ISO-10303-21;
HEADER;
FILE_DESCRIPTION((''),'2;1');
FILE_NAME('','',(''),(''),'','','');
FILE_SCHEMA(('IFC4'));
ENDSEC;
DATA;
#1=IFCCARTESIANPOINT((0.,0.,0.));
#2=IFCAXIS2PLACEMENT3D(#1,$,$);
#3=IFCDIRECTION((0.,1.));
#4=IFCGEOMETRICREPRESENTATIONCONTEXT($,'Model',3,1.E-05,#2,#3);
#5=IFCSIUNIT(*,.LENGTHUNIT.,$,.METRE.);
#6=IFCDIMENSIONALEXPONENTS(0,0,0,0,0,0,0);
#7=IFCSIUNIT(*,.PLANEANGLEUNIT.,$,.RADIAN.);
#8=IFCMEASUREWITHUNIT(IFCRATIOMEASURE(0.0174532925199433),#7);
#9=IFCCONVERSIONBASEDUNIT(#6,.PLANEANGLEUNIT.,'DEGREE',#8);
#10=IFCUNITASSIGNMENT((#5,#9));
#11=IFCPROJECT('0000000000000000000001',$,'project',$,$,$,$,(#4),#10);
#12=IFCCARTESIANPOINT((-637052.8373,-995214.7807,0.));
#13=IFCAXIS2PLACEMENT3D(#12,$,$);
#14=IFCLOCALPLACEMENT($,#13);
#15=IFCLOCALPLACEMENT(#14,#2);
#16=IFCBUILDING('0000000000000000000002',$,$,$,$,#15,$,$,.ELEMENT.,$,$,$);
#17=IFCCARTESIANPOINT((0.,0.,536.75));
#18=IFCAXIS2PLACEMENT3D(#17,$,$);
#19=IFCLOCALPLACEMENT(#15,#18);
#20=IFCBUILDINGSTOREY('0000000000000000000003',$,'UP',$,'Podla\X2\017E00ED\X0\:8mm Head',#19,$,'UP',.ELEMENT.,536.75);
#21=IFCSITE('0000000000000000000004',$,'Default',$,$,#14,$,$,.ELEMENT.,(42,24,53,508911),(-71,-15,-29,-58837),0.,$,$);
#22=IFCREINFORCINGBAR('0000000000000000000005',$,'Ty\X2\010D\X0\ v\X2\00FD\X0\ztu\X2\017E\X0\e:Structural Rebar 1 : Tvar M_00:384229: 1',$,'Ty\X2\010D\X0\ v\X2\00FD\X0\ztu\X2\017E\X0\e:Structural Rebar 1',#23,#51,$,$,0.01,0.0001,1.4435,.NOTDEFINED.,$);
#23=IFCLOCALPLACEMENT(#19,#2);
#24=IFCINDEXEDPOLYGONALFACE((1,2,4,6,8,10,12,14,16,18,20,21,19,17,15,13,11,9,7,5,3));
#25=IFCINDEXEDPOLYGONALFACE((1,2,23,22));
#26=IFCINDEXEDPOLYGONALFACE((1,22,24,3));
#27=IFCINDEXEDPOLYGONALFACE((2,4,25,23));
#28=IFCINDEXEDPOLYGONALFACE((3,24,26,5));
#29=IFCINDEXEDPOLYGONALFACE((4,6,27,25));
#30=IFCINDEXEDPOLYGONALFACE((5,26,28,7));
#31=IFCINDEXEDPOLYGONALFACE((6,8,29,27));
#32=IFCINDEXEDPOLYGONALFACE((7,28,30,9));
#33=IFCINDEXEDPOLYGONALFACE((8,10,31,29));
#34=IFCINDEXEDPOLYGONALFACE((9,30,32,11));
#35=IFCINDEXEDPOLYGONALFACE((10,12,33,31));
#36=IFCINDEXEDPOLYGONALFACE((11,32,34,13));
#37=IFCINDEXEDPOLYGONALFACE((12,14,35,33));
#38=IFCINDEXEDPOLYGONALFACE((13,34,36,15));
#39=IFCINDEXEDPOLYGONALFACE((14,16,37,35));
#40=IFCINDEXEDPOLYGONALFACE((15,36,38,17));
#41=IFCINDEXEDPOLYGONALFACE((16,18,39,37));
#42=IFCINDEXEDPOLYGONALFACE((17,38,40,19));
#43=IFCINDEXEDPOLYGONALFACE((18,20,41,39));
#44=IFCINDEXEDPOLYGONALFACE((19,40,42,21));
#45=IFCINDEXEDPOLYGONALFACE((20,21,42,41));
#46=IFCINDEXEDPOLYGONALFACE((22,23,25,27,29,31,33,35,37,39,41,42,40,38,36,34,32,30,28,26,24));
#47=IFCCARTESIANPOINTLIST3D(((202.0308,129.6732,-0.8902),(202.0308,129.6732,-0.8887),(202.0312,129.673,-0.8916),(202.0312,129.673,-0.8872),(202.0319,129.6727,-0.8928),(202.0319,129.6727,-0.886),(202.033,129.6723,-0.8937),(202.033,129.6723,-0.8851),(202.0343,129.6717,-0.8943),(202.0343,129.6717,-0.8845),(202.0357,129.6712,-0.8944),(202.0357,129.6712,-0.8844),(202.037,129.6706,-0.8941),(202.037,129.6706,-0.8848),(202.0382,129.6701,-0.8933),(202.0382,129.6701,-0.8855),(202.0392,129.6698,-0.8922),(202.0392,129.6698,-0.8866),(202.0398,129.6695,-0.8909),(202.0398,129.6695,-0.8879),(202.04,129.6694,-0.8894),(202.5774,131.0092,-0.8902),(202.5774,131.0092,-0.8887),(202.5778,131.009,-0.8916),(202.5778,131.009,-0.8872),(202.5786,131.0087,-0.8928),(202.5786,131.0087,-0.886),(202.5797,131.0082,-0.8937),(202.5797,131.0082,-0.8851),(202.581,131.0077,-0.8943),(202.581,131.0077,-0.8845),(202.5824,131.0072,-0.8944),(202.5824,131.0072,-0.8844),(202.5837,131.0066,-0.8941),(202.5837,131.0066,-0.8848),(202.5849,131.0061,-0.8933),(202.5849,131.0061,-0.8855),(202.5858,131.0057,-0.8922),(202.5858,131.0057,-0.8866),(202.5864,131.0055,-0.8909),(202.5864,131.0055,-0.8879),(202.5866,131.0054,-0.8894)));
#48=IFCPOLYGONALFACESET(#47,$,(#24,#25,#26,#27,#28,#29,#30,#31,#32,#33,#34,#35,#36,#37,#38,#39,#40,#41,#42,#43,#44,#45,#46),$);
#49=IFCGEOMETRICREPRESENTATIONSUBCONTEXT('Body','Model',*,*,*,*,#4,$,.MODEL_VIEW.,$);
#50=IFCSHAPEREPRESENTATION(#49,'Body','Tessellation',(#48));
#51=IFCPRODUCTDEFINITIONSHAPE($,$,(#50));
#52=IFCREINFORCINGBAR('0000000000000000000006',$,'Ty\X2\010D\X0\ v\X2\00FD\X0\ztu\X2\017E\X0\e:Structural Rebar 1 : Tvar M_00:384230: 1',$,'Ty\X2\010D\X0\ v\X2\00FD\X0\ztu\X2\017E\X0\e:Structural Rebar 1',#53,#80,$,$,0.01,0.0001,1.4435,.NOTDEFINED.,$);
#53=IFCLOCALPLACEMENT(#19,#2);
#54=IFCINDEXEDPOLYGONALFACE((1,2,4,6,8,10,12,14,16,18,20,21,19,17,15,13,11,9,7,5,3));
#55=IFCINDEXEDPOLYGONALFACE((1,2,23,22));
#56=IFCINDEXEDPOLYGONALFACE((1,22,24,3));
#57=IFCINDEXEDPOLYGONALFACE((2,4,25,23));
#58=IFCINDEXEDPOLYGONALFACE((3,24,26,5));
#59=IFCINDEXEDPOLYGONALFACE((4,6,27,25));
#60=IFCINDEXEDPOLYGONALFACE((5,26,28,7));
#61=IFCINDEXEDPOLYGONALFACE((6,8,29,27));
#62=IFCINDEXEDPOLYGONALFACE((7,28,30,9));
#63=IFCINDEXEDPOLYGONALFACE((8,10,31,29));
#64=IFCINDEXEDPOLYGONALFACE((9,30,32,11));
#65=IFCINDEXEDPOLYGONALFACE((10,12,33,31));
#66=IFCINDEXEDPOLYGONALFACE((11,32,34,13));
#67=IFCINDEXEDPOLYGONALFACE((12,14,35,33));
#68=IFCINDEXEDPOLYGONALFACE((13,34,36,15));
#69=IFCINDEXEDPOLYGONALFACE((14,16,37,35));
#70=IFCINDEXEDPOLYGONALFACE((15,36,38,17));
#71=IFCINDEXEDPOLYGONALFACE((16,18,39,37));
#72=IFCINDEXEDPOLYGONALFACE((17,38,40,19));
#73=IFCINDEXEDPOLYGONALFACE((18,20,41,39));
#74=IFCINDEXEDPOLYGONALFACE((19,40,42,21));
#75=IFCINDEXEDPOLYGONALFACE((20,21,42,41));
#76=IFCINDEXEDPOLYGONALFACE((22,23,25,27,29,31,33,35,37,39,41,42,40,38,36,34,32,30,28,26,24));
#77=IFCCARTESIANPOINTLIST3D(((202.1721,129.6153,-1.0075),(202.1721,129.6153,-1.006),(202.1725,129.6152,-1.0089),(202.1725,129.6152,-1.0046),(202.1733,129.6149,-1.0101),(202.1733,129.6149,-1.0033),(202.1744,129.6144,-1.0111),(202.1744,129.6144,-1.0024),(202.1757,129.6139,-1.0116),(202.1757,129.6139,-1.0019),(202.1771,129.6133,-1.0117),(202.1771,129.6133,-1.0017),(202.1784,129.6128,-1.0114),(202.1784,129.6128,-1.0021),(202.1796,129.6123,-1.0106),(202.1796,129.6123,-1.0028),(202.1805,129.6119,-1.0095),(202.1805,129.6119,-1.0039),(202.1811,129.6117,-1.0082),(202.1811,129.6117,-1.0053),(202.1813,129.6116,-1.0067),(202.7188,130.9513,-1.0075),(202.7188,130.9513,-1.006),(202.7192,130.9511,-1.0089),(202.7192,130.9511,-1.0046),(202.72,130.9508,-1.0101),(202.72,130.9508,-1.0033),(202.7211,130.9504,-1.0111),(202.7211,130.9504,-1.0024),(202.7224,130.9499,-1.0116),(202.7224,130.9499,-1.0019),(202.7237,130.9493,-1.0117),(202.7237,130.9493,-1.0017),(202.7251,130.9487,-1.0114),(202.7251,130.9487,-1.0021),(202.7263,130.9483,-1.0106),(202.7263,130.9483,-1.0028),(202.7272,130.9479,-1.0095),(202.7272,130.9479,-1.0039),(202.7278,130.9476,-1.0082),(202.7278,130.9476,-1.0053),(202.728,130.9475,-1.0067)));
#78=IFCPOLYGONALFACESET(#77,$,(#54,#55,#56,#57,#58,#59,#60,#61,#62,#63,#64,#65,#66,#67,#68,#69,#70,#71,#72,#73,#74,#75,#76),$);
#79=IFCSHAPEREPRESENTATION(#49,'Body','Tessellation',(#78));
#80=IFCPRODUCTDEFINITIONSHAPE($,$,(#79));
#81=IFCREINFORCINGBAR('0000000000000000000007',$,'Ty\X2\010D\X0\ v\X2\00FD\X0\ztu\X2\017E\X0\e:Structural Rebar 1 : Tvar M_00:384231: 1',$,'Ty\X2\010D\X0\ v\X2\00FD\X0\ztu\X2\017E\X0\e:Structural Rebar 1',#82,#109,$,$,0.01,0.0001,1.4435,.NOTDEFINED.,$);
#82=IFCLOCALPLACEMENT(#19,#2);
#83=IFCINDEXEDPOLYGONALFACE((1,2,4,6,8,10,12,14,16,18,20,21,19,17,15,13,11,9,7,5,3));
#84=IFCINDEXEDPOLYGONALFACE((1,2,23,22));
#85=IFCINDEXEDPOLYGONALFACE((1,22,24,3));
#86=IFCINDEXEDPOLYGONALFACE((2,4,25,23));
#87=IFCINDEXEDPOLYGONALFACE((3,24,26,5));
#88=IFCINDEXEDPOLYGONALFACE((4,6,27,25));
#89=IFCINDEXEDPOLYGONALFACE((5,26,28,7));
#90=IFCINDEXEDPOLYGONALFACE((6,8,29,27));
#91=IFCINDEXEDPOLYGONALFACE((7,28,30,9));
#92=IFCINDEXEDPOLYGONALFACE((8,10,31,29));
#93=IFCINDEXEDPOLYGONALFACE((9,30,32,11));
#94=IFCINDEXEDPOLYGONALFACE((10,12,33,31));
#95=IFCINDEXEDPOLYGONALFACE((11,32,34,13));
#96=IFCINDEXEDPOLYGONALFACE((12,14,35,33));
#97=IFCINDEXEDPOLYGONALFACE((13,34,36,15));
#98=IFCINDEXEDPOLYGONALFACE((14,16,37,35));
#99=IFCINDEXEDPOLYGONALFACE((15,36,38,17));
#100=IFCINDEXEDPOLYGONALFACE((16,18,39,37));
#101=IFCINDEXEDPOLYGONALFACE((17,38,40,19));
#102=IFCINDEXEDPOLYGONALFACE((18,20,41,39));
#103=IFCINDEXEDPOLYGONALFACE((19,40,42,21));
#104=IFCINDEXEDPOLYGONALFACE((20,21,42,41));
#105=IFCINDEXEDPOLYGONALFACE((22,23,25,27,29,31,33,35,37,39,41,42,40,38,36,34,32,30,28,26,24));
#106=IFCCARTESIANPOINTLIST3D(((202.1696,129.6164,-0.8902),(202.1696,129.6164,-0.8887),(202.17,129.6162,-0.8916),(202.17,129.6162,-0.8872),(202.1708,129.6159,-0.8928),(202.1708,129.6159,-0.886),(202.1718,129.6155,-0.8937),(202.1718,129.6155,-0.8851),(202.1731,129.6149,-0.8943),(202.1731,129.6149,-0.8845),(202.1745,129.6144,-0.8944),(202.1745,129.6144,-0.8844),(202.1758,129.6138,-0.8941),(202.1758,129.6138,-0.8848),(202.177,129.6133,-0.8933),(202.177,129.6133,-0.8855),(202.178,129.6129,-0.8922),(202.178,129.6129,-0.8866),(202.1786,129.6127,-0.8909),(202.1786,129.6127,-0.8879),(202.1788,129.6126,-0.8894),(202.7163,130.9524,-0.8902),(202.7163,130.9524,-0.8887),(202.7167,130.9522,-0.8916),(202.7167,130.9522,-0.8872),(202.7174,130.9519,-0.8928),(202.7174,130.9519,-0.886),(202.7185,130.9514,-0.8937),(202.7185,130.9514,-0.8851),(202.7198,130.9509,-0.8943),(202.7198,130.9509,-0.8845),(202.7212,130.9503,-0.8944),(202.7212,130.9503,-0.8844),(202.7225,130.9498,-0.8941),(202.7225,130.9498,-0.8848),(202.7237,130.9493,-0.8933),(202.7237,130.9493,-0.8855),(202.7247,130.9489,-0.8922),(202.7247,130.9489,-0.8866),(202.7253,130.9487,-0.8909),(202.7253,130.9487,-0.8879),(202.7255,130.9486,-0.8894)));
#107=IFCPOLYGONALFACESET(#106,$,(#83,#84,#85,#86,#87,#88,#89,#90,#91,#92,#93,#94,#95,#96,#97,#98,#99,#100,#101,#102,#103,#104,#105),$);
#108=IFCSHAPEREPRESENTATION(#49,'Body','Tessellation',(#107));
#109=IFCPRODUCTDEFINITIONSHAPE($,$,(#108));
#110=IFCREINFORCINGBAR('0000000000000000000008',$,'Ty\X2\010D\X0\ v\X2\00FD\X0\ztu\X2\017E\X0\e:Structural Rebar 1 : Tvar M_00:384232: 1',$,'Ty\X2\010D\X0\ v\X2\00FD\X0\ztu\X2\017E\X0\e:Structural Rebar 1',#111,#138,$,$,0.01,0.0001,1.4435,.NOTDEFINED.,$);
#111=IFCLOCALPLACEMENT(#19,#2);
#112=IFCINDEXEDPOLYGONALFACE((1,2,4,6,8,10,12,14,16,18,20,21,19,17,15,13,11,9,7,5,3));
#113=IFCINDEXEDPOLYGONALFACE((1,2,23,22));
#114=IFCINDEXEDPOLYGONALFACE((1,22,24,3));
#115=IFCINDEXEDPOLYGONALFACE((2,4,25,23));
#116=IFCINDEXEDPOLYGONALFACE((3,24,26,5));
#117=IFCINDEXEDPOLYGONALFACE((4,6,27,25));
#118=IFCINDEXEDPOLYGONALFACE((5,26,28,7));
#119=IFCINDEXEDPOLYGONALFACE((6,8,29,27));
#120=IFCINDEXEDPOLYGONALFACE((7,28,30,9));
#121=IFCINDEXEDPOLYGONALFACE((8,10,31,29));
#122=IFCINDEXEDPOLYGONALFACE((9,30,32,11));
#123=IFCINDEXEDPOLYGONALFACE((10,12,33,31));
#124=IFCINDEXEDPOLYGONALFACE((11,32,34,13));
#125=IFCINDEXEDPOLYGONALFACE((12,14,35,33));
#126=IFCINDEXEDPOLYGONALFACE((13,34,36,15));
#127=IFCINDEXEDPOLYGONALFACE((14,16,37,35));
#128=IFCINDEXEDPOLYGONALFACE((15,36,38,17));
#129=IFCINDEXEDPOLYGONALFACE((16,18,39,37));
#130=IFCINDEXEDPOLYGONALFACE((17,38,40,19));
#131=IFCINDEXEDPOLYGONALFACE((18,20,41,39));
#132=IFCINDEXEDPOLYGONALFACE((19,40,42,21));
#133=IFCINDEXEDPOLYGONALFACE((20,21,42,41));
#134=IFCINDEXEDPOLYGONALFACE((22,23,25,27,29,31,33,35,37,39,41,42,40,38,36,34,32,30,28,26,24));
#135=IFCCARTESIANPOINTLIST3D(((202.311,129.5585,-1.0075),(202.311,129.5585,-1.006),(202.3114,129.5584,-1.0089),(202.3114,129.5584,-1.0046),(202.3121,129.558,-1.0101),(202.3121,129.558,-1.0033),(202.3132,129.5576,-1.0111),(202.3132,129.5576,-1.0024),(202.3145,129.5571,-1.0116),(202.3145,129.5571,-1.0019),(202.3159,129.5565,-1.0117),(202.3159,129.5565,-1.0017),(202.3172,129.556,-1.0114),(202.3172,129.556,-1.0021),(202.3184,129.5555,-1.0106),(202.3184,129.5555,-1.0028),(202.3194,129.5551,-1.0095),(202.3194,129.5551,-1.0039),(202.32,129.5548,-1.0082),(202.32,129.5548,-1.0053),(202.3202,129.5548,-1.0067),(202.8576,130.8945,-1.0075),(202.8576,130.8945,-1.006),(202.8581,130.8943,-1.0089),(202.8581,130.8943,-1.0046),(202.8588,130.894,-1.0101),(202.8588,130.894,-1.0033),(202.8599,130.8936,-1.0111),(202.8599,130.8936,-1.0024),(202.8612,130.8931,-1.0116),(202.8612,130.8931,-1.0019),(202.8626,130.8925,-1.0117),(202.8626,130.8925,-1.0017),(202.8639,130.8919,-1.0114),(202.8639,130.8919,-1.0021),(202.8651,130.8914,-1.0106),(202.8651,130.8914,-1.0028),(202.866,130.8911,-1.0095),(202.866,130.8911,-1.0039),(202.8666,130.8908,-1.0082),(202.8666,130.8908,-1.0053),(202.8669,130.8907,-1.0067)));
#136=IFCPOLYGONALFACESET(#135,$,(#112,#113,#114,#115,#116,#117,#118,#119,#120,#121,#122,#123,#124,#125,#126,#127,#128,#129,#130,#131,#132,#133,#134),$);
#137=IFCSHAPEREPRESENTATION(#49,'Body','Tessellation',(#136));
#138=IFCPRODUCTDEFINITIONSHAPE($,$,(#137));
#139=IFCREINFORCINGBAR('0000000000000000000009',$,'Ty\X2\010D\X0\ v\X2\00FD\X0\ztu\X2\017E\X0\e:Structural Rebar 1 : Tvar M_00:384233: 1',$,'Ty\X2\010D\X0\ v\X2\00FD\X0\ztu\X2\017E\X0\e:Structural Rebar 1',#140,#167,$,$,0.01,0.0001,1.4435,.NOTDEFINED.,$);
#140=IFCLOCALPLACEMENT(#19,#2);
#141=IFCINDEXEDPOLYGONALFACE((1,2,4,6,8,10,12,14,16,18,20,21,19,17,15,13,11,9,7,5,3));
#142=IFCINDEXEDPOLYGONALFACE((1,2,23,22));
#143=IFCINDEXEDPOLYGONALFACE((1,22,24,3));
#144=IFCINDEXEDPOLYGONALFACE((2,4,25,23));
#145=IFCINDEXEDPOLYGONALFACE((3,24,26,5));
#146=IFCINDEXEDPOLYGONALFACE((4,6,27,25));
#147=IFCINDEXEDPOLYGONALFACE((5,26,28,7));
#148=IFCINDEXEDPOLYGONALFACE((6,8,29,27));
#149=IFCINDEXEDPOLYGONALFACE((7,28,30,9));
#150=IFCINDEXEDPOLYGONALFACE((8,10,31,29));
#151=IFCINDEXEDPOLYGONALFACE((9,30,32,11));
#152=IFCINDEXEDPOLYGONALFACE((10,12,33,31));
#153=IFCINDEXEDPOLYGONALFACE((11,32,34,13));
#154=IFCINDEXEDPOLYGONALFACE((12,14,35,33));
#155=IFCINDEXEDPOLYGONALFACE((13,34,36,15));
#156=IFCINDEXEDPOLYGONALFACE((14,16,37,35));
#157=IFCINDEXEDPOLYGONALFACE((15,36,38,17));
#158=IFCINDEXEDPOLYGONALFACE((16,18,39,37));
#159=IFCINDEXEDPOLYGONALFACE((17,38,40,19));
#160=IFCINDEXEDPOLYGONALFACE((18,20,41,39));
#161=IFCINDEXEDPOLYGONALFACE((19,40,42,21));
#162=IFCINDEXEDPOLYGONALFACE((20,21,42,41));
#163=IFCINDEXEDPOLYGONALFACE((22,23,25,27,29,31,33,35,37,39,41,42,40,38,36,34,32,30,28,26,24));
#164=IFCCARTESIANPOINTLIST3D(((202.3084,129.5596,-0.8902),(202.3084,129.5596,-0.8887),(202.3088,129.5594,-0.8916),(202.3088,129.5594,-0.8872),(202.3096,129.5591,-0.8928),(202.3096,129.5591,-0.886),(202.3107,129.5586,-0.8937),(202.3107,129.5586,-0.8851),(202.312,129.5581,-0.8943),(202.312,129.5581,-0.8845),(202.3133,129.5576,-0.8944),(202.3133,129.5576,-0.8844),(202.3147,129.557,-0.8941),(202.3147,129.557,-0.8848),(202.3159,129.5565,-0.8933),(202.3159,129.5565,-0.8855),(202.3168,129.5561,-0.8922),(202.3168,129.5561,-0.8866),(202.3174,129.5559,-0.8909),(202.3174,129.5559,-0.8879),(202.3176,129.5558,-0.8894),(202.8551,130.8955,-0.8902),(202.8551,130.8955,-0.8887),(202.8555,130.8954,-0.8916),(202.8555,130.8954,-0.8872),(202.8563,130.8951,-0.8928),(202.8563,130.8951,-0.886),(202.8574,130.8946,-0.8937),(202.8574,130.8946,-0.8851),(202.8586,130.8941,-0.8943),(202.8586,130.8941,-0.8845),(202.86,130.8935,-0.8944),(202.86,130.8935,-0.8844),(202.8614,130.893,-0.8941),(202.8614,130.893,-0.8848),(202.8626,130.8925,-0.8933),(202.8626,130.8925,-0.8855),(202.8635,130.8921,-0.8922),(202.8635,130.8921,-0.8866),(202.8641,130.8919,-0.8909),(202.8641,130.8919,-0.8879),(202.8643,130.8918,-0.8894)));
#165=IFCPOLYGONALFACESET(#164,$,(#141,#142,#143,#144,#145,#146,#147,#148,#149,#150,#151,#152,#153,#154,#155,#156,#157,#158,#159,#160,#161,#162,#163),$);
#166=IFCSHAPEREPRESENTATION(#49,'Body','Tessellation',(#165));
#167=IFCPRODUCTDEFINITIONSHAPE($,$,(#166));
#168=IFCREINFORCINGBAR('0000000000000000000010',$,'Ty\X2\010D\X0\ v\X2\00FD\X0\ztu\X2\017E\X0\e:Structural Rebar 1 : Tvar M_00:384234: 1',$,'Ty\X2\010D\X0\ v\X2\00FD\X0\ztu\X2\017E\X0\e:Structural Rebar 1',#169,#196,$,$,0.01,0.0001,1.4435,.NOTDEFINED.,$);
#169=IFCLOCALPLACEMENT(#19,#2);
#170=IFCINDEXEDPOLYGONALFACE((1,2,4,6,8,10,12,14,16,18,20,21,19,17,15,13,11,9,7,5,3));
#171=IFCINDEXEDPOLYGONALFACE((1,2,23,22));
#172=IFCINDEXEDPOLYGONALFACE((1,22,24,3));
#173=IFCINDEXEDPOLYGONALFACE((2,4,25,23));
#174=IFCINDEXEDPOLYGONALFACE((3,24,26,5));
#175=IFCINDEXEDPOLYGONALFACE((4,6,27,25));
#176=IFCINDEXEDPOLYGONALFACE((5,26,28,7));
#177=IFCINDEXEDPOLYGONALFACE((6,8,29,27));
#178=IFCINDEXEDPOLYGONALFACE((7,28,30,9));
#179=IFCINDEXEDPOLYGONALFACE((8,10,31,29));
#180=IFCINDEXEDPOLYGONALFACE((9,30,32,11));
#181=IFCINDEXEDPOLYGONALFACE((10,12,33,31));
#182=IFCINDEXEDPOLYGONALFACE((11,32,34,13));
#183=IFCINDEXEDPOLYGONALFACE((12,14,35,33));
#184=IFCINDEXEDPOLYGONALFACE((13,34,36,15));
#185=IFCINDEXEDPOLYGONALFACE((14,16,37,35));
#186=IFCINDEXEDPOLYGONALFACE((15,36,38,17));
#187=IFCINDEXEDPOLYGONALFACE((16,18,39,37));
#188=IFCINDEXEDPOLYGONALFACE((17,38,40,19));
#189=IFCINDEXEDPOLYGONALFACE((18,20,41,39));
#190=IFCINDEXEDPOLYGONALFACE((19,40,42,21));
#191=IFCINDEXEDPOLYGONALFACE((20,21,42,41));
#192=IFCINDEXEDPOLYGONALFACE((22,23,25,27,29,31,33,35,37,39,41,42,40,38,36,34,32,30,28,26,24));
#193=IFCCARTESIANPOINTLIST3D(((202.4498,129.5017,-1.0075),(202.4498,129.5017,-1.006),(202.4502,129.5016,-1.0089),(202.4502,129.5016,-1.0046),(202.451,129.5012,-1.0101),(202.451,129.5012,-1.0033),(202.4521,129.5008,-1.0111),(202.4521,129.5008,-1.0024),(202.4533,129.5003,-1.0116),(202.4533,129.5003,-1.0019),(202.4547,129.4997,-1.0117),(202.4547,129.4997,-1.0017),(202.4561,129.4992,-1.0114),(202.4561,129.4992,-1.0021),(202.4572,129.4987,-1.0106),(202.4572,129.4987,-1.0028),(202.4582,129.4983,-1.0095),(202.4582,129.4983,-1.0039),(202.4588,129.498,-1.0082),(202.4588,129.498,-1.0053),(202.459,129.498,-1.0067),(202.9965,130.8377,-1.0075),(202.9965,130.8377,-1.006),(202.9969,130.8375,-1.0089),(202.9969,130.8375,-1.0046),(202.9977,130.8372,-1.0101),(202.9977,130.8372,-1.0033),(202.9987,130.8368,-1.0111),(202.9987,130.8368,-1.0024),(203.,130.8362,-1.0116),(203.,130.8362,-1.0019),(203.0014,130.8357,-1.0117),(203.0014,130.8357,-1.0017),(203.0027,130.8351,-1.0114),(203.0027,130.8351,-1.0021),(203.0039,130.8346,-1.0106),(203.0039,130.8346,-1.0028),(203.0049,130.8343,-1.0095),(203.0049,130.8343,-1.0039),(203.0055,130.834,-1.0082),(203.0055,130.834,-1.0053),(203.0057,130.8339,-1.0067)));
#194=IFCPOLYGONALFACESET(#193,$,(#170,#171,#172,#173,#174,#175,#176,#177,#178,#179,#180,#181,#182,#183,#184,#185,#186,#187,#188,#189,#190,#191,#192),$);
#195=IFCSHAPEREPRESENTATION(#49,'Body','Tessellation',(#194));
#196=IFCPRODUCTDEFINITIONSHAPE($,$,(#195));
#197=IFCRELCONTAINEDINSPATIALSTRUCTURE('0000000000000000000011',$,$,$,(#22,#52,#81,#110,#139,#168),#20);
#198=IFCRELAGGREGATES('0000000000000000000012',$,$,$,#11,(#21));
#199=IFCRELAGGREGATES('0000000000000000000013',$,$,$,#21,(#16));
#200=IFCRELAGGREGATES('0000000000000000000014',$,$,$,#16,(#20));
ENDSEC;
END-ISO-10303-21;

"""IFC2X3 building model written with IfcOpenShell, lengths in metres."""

from ifc_helpers import new_model, entity, si_unit, converted_unit, direction, frame, origin, place, context, subcontext, project, spatial, element, save


model = new_model("IFC2X3")

# Units and contexts
model_context = context("Model", 3, precision=1e-05, world=origin(), true_north=direction((0.0, 1.0)))
body_context = subcontext(model_context, "Body", "Model", "MODEL_VIEW")
ifc_project = project(units=[si_unit("LENGTHUNIT", "METRE"), converted_unit("PLANEANGLEUNIT", "DEGREE", entity("IfcRatioMeasure", 0.0174532925199433), si_unit("PLANEANGLEUNIT", "RADIAN"), dimensions=[0, 0, 0, 0, 0, 0, 0])], contexts=[model_context])

# Site, building, storey
site_placement = place(None, frame((-637052.8373, -995214.7807, 0.0)))
site = spatial("IfcSite", under=ifc_project, at=site_placement, Name="Default", CompositionType="ELEMENT", RefLatitude=(42, 24, 53, 508911), RefLongitude=(-71, -15, -29, -58837), RefElevation=0.0)
building_placement = place(site_placement, origin())
building = spatial("IfcBuilding", under=site, at=building_placement, CompositionType="ELEMENT")
storey_placement = place(building_placement, frame((0.0, 0.0, 536.75)))
storey = spatial("IfcBuildingStorey", under=building, at=storey_placement, Name="UP", ObjectType="Podlaží:8mm Head", LongName="UP", CompositionType="ELEMENT", Elevation=536.75)

# Reinforcing bars
reinforcing_bar_1_placement = place(storey_placement, origin())
element("IfcReinforcingBar", 1, at=reinforcing_bar_1_placement, inside=storey, Name="Tyč výztuže:Structural Rebar 1 : Tvar M_00:384229: 1", ObjectType="Tyč výztuže:Structural Rebar 1", BarLength=1.4435, BarRole="NOTDEFINED", CrossSectionArea=0.0001, NominalDiameter=0.01, context=body_context, shape_type="AdvancedSweptSolid", body=[
    entity("IfcSweptDiskSolid", entity("IfcCompositeCurve", [entity("IfcCompositeCurveSegment", "CONTINUOUS", True, entity("IfcPolyline", [entity("IfcCartesianPoint", [-202.582, -131.0073, 0.8894]), entity("IfcCartesianPoint", [-202.0353, -129.6713, 0.8894])]))], False), 0.005, None, 0.0, 1.0),
])
reinforcing_bar_2_placement = place(storey_placement, origin())
element("IfcReinforcingBar", 2, at=reinforcing_bar_2_placement, inside=storey, Name="Tyč výztuže:Structural Rebar 1 : Tvar M_00:384230: 1", ObjectType="Tyč výztuže:Structural Rebar 1", BarLength=1.4435, BarRole="NOTDEFINED", CrossSectionArea=0.0001, NominalDiameter=0.01, context=body_context, shape_type="AdvancedSweptSolid", body=[
    entity("IfcSweptDiskSolid", entity("IfcCompositeCurve", [entity("IfcCompositeCurveSegment", "CONTINUOUS", True, entity("IfcPolyline", [entity("IfcCartesianPoint", [-202.7234, -130.9494, 1.0067]), entity("IfcCartesianPoint", [-202.1767, -129.6135, 1.0067])]))], False), 0.005, None, 0.0, 1.0),
])
reinforcing_bar_3_placement = place(storey_placement, origin())
element("IfcReinforcingBar", 3, at=reinforcing_bar_3_placement, inside=storey, Name="Tyč výztuže:Structural Rebar 1 : Tvar M_00:384231: 1", ObjectType="Tyč výztuže:Structural Rebar 1", BarLength=1.4435, BarRole="NOTDEFINED", CrossSectionArea=0.0001, NominalDiameter=0.01, context=body_context, shape_type="AdvancedSweptSolid", body=[
    entity("IfcSweptDiskSolid", entity("IfcCompositeCurve", [entity("IfcCompositeCurveSegment", "CONTINUOUS", True, entity("IfcPolyline", [entity("IfcCartesianPoint", [-202.7208, -130.9505, 0.8894]), entity("IfcCartesianPoint", [-202.1742, -129.6145, 0.8894])]))], False), 0.005, None, 0.0, 1.0),
])
reinforcing_bar_4_placement = place(storey_placement, origin())
element("IfcReinforcingBar", 4, at=reinforcing_bar_4_placement, inside=storey, Name="Tyč výztuže:Structural Rebar 1 : Tvar M_00:384232: 1", ObjectType="Tyč výztuže:Structural Rebar 1", BarLength=1.4435, BarRole="NOTDEFINED", CrossSectionArea=0.0001, NominalDiameter=0.01, context=body_context, shape_type="AdvancedSweptSolid", body=[
    entity("IfcSweptDiskSolid", entity("IfcCompositeCurve", [entity("IfcCompositeCurveSegment", "CONTINUOUS", True, entity("IfcPolyline", [entity("IfcCartesianPoint", [-202.8622, -130.8926, 1.0067]), entity("IfcCartesianPoint", [-202.3155, -129.5567, 1.0067])]))], False), 0.005, None, 0.0, 1.0),
])
reinforcing_bar_5_placement = place(storey_placement, origin())
element("IfcReinforcingBar", 5, at=reinforcing_bar_5_placement, inside=storey, Name="Tyč výztuže:Structural Rebar 1 : Tvar M_00:384233: 1", ObjectType="Tyč výztuže:Structural Rebar 1", BarLength=1.4435, BarRole="NOTDEFINED", CrossSectionArea=0.0001, NominalDiameter=0.01, context=body_context, shape_type="AdvancedSweptSolid", body=[
    entity("IfcSweptDiskSolid", entity("IfcCompositeCurve", [entity("IfcCompositeCurveSegment", "CONTINUOUS", True, entity("IfcPolyline", [entity("IfcCartesianPoint", [-202.8597, -130.8937, 0.8894]), entity("IfcCartesianPoint", [-202.313, -129.5577, 0.8894])]))], False), 0.005, None, 0.0, 1.0),
])
reinforcing_bar_6_placement = place(storey_placement, origin())
element("IfcReinforcingBar", 6, at=reinforcing_bar_6_placement, inside=storey, Name="Tyč výztuže:Structural Rebar 1 : Tvar M_00:384234: 1", ObjectType="Tyč výztuže:Structural Rebar 1", BarLength=1.4435, BarRole="NOTDEFINED", CrossSectionArea=0.0001, NominalDiameter=0.01, context=body_context, shape_type="AdvancedSweptSolid", body=[
    entity("IfcSweptDiskSolid", entity("IfcCompositeCurve", [entity("IfcCompositeCurveSegment", "CONTINUOUS", True, entity("IfcPolyline", [entity("IfcCartesianPoint", [-203.001, -130.8358, 1.0067]), entity("IfcCartesianPoint", [-202.4544, -129.4998, 1.0067])]))], False), 0.005, None, 0.0, 1.0),
])

save(model, "model.ifc")
